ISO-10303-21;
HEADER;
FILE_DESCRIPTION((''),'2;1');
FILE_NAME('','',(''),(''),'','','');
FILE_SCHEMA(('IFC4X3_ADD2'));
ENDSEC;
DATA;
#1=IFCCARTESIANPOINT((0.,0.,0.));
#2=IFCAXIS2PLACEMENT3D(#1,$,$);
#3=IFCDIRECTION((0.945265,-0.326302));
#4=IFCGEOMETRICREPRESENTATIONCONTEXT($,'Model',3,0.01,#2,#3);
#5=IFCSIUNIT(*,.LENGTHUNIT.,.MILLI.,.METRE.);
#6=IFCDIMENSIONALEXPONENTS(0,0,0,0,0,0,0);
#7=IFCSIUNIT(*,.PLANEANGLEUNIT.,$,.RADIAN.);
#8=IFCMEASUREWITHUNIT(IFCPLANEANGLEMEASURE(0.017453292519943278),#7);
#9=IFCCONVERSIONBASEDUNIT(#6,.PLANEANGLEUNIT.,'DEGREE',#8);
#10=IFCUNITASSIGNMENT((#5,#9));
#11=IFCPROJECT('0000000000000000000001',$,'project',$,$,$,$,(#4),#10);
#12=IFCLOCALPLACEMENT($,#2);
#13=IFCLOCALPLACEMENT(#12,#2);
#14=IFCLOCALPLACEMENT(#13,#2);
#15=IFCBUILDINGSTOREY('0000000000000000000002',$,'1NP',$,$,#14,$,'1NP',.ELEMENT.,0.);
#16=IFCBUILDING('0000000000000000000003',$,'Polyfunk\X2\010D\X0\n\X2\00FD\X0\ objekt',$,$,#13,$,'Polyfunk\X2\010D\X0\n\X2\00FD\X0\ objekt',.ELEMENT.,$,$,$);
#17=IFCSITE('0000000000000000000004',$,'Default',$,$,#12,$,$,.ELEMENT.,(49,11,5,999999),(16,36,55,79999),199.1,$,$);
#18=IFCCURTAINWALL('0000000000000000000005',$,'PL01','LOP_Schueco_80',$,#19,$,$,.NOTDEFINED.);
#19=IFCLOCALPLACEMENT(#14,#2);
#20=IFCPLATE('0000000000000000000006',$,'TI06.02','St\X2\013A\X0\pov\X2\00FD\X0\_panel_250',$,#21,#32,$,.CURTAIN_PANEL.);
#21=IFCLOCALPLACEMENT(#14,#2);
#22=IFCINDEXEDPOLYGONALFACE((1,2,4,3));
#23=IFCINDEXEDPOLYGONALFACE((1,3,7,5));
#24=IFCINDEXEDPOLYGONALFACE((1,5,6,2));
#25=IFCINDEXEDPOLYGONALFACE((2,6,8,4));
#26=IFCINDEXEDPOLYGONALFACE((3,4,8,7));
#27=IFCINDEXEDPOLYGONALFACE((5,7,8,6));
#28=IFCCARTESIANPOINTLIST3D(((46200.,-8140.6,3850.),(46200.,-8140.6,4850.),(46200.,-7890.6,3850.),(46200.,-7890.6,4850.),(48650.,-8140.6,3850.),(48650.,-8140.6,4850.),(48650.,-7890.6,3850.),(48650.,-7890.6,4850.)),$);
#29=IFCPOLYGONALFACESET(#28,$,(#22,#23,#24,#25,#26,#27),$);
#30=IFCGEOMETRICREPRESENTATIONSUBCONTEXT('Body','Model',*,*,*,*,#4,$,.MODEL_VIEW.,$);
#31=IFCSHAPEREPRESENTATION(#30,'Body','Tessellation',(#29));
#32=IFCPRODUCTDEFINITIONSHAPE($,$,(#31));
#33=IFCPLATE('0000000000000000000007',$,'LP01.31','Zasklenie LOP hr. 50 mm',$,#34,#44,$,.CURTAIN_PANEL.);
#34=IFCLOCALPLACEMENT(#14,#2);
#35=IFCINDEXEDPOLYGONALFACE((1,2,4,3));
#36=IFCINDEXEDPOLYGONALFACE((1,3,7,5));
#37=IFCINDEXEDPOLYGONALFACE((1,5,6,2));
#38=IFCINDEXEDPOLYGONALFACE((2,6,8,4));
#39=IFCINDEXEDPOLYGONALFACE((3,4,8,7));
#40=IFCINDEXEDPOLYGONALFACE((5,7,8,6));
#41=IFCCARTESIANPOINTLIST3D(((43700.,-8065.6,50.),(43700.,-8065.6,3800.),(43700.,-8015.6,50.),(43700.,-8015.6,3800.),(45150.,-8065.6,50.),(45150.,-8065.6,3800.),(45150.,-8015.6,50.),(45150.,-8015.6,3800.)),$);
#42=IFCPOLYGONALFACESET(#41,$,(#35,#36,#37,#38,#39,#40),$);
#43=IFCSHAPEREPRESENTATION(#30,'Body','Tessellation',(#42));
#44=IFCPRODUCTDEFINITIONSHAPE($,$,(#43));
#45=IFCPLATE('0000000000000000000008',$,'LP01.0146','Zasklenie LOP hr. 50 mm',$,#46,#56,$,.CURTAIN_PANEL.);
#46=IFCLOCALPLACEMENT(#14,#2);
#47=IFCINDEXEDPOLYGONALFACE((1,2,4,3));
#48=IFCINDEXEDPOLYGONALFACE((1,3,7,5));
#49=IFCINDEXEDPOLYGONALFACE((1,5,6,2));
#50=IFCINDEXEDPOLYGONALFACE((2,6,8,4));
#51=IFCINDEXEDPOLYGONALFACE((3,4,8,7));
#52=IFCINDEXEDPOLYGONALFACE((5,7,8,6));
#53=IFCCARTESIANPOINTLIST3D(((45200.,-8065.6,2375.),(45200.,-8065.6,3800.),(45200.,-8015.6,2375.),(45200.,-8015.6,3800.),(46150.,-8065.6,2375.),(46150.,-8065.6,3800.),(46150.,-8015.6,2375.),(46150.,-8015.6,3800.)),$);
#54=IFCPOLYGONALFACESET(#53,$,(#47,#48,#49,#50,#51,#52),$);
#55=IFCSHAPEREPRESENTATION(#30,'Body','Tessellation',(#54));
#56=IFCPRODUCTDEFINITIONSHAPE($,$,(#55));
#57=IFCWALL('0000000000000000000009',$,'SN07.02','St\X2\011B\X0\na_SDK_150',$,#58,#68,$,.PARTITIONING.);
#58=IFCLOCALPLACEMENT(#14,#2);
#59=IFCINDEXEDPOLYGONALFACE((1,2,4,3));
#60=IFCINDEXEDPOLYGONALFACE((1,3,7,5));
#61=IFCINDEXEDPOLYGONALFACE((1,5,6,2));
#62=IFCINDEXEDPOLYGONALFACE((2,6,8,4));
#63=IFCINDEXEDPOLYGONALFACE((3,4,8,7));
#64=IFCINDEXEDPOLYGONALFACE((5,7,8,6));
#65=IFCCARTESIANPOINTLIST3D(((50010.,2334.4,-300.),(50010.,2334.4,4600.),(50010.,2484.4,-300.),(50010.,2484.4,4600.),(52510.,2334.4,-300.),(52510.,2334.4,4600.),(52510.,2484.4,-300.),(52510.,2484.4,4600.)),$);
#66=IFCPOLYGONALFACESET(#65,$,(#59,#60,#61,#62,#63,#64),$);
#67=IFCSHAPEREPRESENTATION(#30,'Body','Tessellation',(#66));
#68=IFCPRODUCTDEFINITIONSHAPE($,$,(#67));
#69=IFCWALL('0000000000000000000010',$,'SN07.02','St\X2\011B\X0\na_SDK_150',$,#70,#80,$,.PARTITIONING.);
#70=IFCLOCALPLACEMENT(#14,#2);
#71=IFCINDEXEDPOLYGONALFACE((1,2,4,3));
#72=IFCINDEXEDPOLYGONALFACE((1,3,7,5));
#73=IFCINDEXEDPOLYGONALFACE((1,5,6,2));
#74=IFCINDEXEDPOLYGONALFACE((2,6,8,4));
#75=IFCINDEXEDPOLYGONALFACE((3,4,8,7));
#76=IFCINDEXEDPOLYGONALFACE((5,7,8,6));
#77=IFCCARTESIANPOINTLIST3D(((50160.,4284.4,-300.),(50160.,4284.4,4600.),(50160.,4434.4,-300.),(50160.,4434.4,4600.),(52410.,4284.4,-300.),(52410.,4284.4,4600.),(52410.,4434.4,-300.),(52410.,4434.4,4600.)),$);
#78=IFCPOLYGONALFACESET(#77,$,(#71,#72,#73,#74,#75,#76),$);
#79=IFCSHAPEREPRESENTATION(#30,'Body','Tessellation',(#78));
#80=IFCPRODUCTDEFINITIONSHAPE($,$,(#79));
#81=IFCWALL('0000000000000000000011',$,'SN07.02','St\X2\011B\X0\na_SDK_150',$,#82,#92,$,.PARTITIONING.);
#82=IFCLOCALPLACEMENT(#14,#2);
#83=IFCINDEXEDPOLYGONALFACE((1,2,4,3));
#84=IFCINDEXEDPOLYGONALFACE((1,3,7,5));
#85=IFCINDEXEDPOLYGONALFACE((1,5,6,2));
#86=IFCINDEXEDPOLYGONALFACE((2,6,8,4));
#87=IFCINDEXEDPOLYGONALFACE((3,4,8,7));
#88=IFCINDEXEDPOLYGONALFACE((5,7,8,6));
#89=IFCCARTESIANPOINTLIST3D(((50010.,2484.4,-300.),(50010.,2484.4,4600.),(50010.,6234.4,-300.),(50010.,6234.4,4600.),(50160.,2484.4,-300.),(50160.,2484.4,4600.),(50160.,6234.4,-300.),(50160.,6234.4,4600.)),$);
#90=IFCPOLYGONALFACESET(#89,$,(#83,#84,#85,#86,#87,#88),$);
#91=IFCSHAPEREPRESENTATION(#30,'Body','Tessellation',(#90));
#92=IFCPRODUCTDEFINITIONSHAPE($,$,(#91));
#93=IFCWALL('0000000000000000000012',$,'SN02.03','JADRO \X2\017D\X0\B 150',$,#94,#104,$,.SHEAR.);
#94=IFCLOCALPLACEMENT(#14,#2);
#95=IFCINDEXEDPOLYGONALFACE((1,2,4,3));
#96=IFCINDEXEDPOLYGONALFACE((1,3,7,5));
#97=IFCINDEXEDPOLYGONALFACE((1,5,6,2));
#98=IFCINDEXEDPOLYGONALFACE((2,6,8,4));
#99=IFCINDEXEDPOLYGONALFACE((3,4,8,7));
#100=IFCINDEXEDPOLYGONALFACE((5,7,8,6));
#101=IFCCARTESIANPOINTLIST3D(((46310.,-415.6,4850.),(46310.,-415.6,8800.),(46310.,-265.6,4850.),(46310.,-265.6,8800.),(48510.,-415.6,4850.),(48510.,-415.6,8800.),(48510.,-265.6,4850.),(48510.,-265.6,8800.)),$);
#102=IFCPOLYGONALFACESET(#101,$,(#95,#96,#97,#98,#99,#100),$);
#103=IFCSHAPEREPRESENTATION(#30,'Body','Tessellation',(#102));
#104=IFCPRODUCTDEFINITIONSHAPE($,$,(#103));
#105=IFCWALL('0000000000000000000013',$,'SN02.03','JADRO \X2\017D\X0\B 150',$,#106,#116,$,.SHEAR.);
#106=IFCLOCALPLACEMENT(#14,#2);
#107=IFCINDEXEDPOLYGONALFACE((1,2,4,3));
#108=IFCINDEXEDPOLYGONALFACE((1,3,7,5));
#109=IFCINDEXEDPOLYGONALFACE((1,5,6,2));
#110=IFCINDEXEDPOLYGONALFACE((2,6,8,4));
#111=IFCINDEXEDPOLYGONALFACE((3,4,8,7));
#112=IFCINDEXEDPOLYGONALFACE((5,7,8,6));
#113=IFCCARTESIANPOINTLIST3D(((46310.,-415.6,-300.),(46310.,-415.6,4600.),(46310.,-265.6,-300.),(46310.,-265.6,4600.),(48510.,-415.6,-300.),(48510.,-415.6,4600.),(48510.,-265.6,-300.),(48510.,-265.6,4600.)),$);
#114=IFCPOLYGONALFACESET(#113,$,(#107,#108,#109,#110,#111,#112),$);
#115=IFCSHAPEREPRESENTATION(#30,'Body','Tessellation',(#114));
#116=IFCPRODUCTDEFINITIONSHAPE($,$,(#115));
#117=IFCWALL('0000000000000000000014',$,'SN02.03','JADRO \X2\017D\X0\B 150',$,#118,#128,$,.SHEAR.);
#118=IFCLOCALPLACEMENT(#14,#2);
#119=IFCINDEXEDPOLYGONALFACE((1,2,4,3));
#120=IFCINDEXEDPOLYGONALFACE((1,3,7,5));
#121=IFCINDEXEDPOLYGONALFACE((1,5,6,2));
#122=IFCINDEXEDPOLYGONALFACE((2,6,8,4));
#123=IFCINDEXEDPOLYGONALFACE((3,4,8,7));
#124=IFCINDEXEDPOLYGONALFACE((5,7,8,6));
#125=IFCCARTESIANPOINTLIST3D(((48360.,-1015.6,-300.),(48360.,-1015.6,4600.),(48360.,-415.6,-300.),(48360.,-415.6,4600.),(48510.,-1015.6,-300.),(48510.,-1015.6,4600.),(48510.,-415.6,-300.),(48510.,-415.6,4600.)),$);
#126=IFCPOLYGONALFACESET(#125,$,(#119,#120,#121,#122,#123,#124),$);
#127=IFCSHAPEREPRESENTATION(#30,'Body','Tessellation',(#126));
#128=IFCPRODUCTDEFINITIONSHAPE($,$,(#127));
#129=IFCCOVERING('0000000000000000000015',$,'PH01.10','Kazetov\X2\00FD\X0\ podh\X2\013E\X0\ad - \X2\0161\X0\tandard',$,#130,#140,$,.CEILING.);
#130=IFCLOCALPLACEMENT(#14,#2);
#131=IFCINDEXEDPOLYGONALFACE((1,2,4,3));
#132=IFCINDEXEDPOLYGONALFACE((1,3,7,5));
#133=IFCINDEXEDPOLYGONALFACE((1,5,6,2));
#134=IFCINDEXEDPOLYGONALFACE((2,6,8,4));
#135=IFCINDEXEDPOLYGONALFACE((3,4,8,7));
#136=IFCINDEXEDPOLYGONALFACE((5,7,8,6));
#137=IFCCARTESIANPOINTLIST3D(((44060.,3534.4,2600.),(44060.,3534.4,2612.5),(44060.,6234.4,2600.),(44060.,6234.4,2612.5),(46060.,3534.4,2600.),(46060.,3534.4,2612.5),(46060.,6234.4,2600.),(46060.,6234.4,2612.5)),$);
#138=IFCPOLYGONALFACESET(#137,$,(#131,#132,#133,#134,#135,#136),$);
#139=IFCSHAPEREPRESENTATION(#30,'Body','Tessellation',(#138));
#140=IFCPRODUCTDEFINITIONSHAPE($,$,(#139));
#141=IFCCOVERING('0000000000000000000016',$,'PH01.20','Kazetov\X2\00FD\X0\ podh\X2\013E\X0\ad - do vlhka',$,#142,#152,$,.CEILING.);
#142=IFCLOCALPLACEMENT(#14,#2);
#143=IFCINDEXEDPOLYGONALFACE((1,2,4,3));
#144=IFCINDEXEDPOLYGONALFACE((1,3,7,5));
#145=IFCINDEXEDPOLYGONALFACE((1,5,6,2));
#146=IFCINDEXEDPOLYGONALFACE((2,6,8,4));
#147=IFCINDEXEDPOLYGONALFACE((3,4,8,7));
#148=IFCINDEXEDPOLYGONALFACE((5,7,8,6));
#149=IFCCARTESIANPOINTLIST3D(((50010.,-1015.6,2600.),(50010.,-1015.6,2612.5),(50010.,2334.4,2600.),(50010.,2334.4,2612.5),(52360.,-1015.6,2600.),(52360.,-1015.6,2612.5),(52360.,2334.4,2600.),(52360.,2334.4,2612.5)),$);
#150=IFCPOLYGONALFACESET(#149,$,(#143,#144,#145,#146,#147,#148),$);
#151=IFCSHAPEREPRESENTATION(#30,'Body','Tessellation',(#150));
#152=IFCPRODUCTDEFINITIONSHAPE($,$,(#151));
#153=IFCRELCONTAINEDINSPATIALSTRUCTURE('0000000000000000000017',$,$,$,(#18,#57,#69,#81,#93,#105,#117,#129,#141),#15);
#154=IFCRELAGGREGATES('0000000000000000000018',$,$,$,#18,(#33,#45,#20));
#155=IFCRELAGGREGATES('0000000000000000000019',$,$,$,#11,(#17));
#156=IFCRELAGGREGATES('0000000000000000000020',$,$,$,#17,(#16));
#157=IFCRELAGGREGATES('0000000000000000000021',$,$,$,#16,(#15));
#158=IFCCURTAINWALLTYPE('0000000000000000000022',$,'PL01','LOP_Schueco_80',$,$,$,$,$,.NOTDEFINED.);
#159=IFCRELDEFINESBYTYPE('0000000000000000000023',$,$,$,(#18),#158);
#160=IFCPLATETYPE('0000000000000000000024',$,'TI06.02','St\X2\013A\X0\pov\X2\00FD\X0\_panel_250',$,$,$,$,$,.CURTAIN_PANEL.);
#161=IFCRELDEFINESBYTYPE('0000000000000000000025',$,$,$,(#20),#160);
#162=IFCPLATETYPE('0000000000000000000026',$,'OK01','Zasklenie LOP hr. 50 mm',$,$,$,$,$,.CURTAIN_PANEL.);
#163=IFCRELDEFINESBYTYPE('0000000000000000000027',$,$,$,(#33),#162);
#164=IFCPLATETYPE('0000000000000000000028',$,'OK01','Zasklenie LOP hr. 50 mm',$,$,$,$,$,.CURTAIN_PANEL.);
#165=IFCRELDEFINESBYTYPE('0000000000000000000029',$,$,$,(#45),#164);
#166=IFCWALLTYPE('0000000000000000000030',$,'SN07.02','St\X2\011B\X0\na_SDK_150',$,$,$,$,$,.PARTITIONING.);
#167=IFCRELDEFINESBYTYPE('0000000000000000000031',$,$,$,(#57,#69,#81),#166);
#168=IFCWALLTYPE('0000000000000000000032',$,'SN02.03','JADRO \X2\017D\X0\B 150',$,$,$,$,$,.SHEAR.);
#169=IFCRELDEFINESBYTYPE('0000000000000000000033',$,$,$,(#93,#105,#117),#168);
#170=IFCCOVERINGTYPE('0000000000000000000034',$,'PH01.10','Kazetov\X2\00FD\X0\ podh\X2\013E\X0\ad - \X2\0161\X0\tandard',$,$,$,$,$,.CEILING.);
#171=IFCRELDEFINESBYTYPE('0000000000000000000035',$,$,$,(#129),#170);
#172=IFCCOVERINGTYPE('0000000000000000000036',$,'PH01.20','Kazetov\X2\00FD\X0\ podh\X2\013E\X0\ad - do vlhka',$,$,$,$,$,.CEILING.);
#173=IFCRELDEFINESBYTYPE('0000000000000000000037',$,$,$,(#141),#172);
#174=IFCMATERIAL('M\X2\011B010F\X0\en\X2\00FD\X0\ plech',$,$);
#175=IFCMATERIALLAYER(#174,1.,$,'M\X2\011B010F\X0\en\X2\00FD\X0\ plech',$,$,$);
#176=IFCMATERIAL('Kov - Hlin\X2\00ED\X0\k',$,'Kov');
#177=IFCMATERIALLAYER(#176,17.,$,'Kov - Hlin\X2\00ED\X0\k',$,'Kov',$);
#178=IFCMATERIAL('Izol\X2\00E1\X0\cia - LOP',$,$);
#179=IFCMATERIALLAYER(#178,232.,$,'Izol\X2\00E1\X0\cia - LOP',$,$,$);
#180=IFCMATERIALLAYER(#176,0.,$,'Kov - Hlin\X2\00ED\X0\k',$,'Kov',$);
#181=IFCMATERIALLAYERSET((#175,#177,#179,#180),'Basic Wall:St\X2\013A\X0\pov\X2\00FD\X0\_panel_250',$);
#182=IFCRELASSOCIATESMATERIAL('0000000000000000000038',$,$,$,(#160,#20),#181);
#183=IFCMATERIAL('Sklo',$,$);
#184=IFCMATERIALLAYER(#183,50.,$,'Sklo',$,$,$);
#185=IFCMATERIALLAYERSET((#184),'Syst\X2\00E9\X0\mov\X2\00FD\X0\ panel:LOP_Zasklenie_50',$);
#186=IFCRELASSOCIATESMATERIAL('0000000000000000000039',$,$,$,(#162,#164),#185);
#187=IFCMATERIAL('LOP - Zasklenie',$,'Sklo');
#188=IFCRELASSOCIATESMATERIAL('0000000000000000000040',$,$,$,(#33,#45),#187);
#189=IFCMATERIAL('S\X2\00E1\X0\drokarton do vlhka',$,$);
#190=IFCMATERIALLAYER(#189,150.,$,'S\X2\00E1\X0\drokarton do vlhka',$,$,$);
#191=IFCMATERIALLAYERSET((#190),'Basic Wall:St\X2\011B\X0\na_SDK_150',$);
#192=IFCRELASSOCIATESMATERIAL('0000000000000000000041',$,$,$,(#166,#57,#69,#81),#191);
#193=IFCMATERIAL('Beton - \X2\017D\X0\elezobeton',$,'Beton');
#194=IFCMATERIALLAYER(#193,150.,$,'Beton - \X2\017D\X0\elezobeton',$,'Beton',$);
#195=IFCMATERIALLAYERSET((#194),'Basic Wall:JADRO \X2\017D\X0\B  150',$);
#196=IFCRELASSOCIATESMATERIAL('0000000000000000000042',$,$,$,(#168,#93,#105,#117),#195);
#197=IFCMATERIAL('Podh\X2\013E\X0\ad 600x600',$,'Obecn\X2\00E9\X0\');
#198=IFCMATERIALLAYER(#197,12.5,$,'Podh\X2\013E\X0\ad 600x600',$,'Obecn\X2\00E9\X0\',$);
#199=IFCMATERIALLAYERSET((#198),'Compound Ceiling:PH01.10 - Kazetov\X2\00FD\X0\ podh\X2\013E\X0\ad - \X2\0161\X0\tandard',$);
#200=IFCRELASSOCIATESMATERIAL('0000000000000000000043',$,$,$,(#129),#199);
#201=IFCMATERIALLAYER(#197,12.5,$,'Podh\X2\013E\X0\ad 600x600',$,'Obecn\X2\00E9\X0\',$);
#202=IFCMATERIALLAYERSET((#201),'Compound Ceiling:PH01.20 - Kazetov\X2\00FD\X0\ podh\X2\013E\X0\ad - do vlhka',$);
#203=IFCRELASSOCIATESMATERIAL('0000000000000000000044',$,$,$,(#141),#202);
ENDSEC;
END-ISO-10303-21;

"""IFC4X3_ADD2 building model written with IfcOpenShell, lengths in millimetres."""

from ifc_helpers import new_model, entity, si_unit, converted_unit, direction, frame, frame_2d, origin, origin_2d_with_axis, place, context, subcontext, project, spatial, polyline, rectangle, extrude, clip, bounded_halfspace, source, transform, mapped, material, layer, layer_set, layer_usage, type_object, type_shapes, element, aggregate, save


model = new_model("IFC4X3_ADD2")

# Units and contexts
model_context = context("Model", 3, precision=0.01, world=origin(), true_north=direction((0.945265, -0.326302)))
body_context = subcontext(model_context, "Body", "Model", "MODEL_VIEW")
ifc_project = project(units=[si_unit("LENGTHUNIT", "METRE", prefix="MILLI"), converted_unit("PLANEANGLEUNIT", "DEGREE", entity("IfcPlaneAngleMeasure", 0.017453292519943278), si_unit("PLANEANGLEUNIT", "RADIAN"), dimensions=[0, 0, 0, 0, 0, 0, 0])], contexts=[model_context])

# Site, building, storey
site_placement = place(None, origin())
site = spatial("IfcSite", under=ifc_project, at=site_placement, Name="Default", CompositionType="ELEMENT", RefLatitude=(49, 11, 5, 999999), RefLongitude=(16, 36, 55, 79999), RefElevation=199.1)
building_placement = place(site_placement, origin())
building = spatial("IfcBuilding", under=site, at=building_placement, Name="Polyfunkčný objekt", LongName="Polyfunkčný objekt", CompositionType="ELEMENT")
storey_placement = place(building_placement, origin())
storey = spatial("IfcBuildingStorey", under=building, at=storey_placement, Name="1NP", LongName="1NP", CompositionType="ELEMENT", Elevation=0.0)

# Curtain wall, plates
curtain_wall_type = type_object("IfcCurtainWallType", Name="PL01", Description="LOP_Schueco_80", PredefinedType="NOTDEFINED")
curtain_wall_placement = place(storey_placement, origin())
curtain_wall = element("IfcCurtainWall", 1, at=curtain_wall_placement, inside=storey, type_object=curtain_wall_type, Name="PL01", Description="LOP_Schueco_80", PredefinedType="NOTDEFINED")
ifc_material_1 = material(Name="Měďený plech")
ifc_layer_1 = layer(ifc_material_1, 1.0, Name="Měďený plech")
ifc_material_2 = material(Name="Kov - Hliník", Category="Kov")
ifc_layer_2 = layer(ifc_material_2, 17.0, Name="Kov - Hliník", Category="Kov")
ifc_material_3 = material(Name="Izolácia - LOP")
ifc_layer_3 = layer(ifc_material_3, 232.0, Name="Izolácia - LOP")
ifc_layer_4 = layer(ifc_material_2, 0.0, Name="Kov - Hliník", Category="Kov")
ifc_layer_set_1 = layer_set([ifc_layer_1, ifc_layer_2, ifc_layer_3, ifc_layer_4], Name="Basic Wall:Stĺpový_panel_250")
ifc_layer_usage_1 = layer_usage(ifc_layer_set_1, "AXIS2", "POSITIVE", -125.0)
plate_type_1 = type_object("IfcPlateType", Name="TI06.02", Description="Stĺpový_panel_250", PredefinedType="CURTAIN_PANEL", material=ifc_layer_set_1)
plate_1_placement = place(storey_placement, frame((46200.0, -8015.6, 3850.0)))
plate_1 = element("IfcPlate", 2, at=plate_1_placement, type_object=plate_type_1, material=ifc_layer_usage_1, Name="TI06.02", Description="Stĺpový_panel_250", PredefinedType="CURTAIN_PANEL", context=body_context, shape_type="SweptSolid", body=[
    extrude(rectangle(XDim=250.0, YDim=2450.0, at=origin_2d_with_axis()), frame((1225.0, 0.0, 0.0), z_axis=(0.0, 0.0, 1.0), x_axis=(0.0, 1.0, 0.0)), (0.0, 0.0, 1.0), 1000.0),
])
ifc_material_4 = material(Name="LOP - Zasklenie", Category="Sklo")
ifc_material_5 = material(Name="Sklo")
ifc_layer_5 = layer(ifc_material_5, 50.0, Name="Sklo")
ifc_layer_set_2 = layer_set([ifc_layer_5], Name="Systémový panel:LOP_Zasklenie_50")
plate_type_2 = type_object("IfcPlateType", Name="OK01", Description="Zasklenie LOP hr. 50 mm", PredefinedType="CURTAIN_PANEL", material=ifc_layer_set_2)
shared_shape_1 = source(origin(), body_context, "Body", "SweptSolid", [
    extrude(rectangle(XDim=3750.0, YDim=1450.0, at=frame_2d((-331.2, 0.0), x_axis=(1.0, 0.0))), frame((0.0, -50.0, 2206.2), z_axis=(0.0, 1.0, 0.0), x_axis=(0.0, 0.0, 1.0)), (0.0, 0.0, 1.0), 50.0),
])
type_shapes(plate_type_2, [shared_shape_1])
plate_2_placement = place(curtain_wall_placement, frame((44425.0, -8015.6, 50.0)))
plate_2 = element("IfcPlate", 3, at=plate_2_placement, type_object=plate_type_2, material=ifc_material_4, Name="LP01.31", Description="Zasklenie LOP hr. 50 mm", PredefinedType="CURTAIN_PANEL", context=body_context, shape_type="MappedRepresentation", body=[
    mapped(shared_shape_1, transform((0.0, 0.0, 0.0), scale=1.0)),
])
plate_type_3 = type_object("IfcPlateType", Name="OK01", Description="Zasklenie LOP hr. 50 mm", PredefinedType="CURTAIN_PANEL", material=ifc_layer_set_2)
shared_shape_2 = source(origin(), body_context, "Body", "SweptSolid", [
    extrude(rectangle(XDim=1425.0, YDim=950.0, at=frame_2d((87.6, 0.0), x_axis=(1.0, 0.0))), frame((0.0, -50.0, 624.9), z_axis=(0.0, 1.0, 0.0), x_axis=(0.0, 0.0, 1.0)), (0.0, 0.0, 1.0), 50.0),
])
type_shapes(plate_type_3, [shared_shape_2])
plate_3_placement = place(curtain_wall_placement, frame((45675.0, -8015.6, 2375.0)))
plate_3 = element("IfcPlate", 4, at=plate_3_placement, type_object=plate_type_3, material=ifc_material_4, Name="LP01.0146", Description="Zasklenie LOP hr. 50 mm", PredefinedType="CURTAIN_PANEL", context=body_context, shape_type="MappedRepresentation", body=[
    mapped(shared_shape_2, transform((0.0, 0.0, 0.0), scale=1.0)),
])
aggregate(curtain_wall, [plate_2, plate_3, plate_1])

# Walls
ifc_material_6 = material(Name="Sádrokarton do vlhka")
ifc_layer_6 = layer(ifc_material_6, 150.0, Name="Sádrokarton do vlhka")
ifc_layer_set_3 = layer_set([ifc_layer_6], Name="Basic Wall:Stěna_SDK_150")
wall_type_1 = type_object("IfcWallType", Name="SN07.02", Description="Stěna_SDK_150", PredefinedType="PARTITIONING", material=ifc_layer_set_3)
wall_1_placement = place(storey_placement, frame((50010.0, 2409.4, -300.0)))
element("IfcWall", 5, at=wall_1_placement, inside=storey, type_object=wall_type_1, material=ifc_layer_set_3, Name="SN07.02", Description="Stěna_SDK_150", PredefinedType="PARTITIONING", context=body_context, shape_type="Clipping", body=[
    clip(clip(extrude(rectangle(XDim=2500.0, YDim=150.0, at=frame_2d((1250.0, 0.0), x_axis=(-1.0, 0.0))), origin(), (0.0, 0.0, 1.0), 4900.0), bounded_halfspace(frame((2500.0, -75.0, 0.0), z_axis=(0.0, 0.0, 1.0), x_axis=(0.0, 1.0, 0.0)), True, frame((2500.0, -75.0, 0.0)), polyline([(0.0, 0.0), (0.0, 150.0), (-100.0, 150.0), (-2350.0, 150.0), (-2500.0, 150.0), (-2500.0, 0.0), (-150.0, 0.0), (0.0, 0.0)]))), bounded_halfspace(frame((0.0, -75.0, 4900.0), z_axis=(0.0, 0.0, -1.0), x_axis=(1.0, 0.0, 0.0)), True, frame((0.0, -75.0, 4900.0)), polyline([(0.0, 0.0), (2350.0, 0.0), (2500.0, 0.0), (2500.0, 150.0), (2400.0, 150.0), (150.0, 150.0), (0.0, 150.0), (0.0, 0.0)]))),
])
wall_2_placement = place(storey_placement, frame((50160.0, 4359.4, -300.0)))
element("IfcWall", 6, at=wall_2_placement, inside=storey, type_object=wall_type_1, material=ifc_layer_set_3, Name="SN07.02", Description="Stěna_SDK_150", PredefinedType="PARTITIONING", context=body_context, shape_type="Clipping", body=[
    clip(clip(extrude(rectangle(XDim=2250.0, YDim=150.0, at=frame_2d((1125.0, 0.0), x_axis=(-1.0, 0.0))), origin(), (0.0, 0.0, 1.0), 4900.0), bounded_halfspace(frame((2250.0, -75.0, 0.0), z_axis=(0.0, 0.0, 1.0), x_axis=(0.0, 1.0, 0.0)), True, frame((2250.0, -75.0, 0.0)), polyline([(0.0, 0.0), (0.0, 150.0), (-2250.0, 150.0), (-2250.0, 0.0), (0.0, 0.0)]))), bounded_halfspace(frame((0.0, -75.0, 4900.0), z_axis=(0.0, 0.0, -1.0), x_axis=(1.0, 0.0, 0.0)), True, frame((0.0, -75.0, 4900.0)), polyline([(0.0, 0.0), (2250.0, 0.0), (2250.0, 150.0), (0.0, 150.0), (0.0, 0.0)]))),
])
wall_3_placement = place(storey_placement, frame((50085.0, 2484.4, -300.0), z_axis=(0.0, 0.0, 1.0), x_axis=(0.0, 1.0, 0.0)))
element("IfcWall", 7, at=wall_3_placement, inside=storey, type_object=wall_type_1, material=ifc_layer_set_3, Name="SN07.02", Description="Stěna_SDK_150", PredefinedType="PARTITIONING", context=body_context, shape_type="Clipping", body=[
    clip(clip(extrude(rectangle(XDim=3750.0, YDim=150.0, at=frame_2d((1875.0, 0.0), x_axis=(-1.0, 0.0))), origin(), (0.0, 0.0, 1.0), 4900.0), bounded_halfspace(frame((0.0, -75.0, 4900.0), z_axis=(0.0, 0.0, -1.0), x_axis=(0.0, -1.0, 0.0)), True, frame((0.0, -75.0, 4900.0)), polyline([(0.0, 0.0), (1800.0, 0.0), (1950.0, 0.0), (3750.0, 0.0), (3750.0, 150.0), (0.0, 150.0), (0.0, 0.0)]))), bounded_halfspace(frame((3750.0, -75.0, 0.0)), True, frame((3750.0, -75.0, 0.0)), polyline([(0.0, 0.0), (0.0, 150.0), (-3750.0, 150.0), (-3750.0, 0.0), (-1950.0, 0.0), (-1800.0, 0.0), (0.0, 0.0)]))),
])
ifc_material_7 = material(Name="Beton - Železobeton", Category="Beton")
ifc_layer_7 = layer(ifc_material_7, 150.0, Name="Beton - Železobeton", Category="Beton")
ifc_layer_set_4 = layer_set([ifc_layer_7], Name="Basic Wall:JADRO ŽB  150")
wall_type_2 = type_object("IfcWallType", Name="SN02.03", Description="JADRO ŽB 150", PredefinedType="SHEAR", material=ifc_layer_set_4)
wall_4_placement = place(storey_placement, frame((46310.0, -340.6, 4850.0)))
element("IfcWall", 8, at=wall_4_placement, inside=storey, type_object=wall_type_2, material=ifc_layer_set_4, Name="SN02.03", Description="JADRO ŽB 150", PredefinedType="SHEAR", context=body_context, shape_type="Clipping", body=[
    clip(clip(extrude(rectangle(XDim=2200.0, YDim=150.0, at=frame_2d((1100.0, 0.0), x_axis=(-1.0, 0.0))), origin(), (0.0, 0.0, 1.0), 3950.0), bounded_halfspace(frame((2200.0, -75.0, 0.0), z_axis=(0.0, 0.0, 1.0), x_axis=(-1.0, 0.0, 0.0)), True, frame((2200.0, -75.0, 0.0)), polyline([(0.0, 0.0), (0.0, 150.0), (-2200.0, 150.0), (-2200.0, 0.0), (0.0, 0.0)]))), bounded_halfspace(frame((0.0, -75.0, 3950.0), z_axis=(0.0, 0.0, -1.0), x_axis=(1.0, 0.0, 0.0)), True, frame((0.0, -75.0, 3950.0)), polyline([(0.0, 0.0), (2050.0, 0.0), (2200.0, 0.0), (2200.0, 150.0), (0.0, 150.0), (0.0, 0.0)]))),
])
wall_5_placement = place(storey_placement, frame((46310.0, -340.6, -300.0)))
element("IfcWall", 9, at=wall_5_placement, inside=storey, type_object=wall_type_2, material=ifc_layer_set_4, Name="SN02.03", Description="JADRO ŽB 150", PredefinedType="SHEAR", context=body_context, shape_type="SweptSolid", body=[
    extrude(rectangle(XDim=2200.0, YDim=150.0, at=frame_2d((1100.0, 0.0), x_axis=(-1.0, 0.0))), origin(), (0.0, 0.0, 1.0), 4900.0),
])
wall_6_placement = place(storey_placement, frame((48435.0, -1015.6, -300.0), z_axis=(0.0, 0.0, 1.0), x_axis=(0.0, 1.0, 0.0)))
element("IfcWall", 10, at=wall_6_placement, inside=storey, type_object=wall_type_2, material=ifc_layer_set_4, Name="SN02.03", Description="JADRO ŽB 150", PredefinedType="SHEAR", context=body_context, shape_type="SweptSolid", body=[
    extrude(rectangle(XDim=600.0, YDim=150.0, at=frame_2d((300.0, 0.0), x_axis=(-1.0, 0.0))), origin(), (0.0, 0.0, 1.0), 4900.0),
])

# Coverings
ifc_material_8 = material(Name="Podhľad 600x600", Category="Obecné")
ifc_layer_8 = layer(ifc_material_8, 12.5, Name="Podhľad 600x600", Category="Obecné")
ifc_layer_set_5 = layer_set([ifc_layer_8], Name="Compound Ceiling:PH01.10 - Kazetový podhľad - štandard")
ifc_layer_usage_2 = layer_usage(ifc_layer_set_5, "AXIS3", "NEGATIVE", 0.0)
covering_type_1 = type_object("IfcCoveringType", Name="PH01.10", Description="Kazetový podhľad - štandard", PredefinedType="CEILING")
covering_1_placement = place(storey_placement, frame((44060.0, 3534.4, 2600.0)))
element("IfcCovering", 11, at=covering_1_placement, inside=storey, type_object=covering_type_1, material=ifc_layer_usage_2, Name="PH01.10", Description="Kazetový podhľad - štandard", PredefinedType="CEILING", context=body_context, shape_type="SweptSolid", body=[
    extrude(rectangle(XDim=2000.0, YDim=2700.0, at=frame_2d((0.0, 0.0), x_axis=(1.0, 0.0))), frame((1000.0, 1350.0, 0.0)), (0.0, 0.0, 1.0), 12.5),
])
ifc_layer_9 = layer(ifc_material_8, 12.5, Name="Podhľad 600x600", Category="Obecné")
ifc_layer_set_6 = layer_set([ifc_layer_9], Name="Compound Ceiling:PH01.20 - Kazetový podhľad - do vlhka")
ifc_layer_usage_3 = layer_usage(ifc_layer_set_6, "AXIS3", "NEGATIVE", 12.5)
covering_type_2 = type_object("IfcCoveringType", Name="PH01.20", Description="Kazetový podhľad - do vlhka", PredefinedType="CEILING")
covering_2_placement = place(storey_placement, frame((50010.0, -1015.6, 2600.0)))
element("IfcCovering", 12, at=covering_2_placement, inside=storey, type_object=covering_type_2, material=ifc_layer_usage_3, Name="PH01.20", Description="Kazetový podhľad - do vlhka", PredefinedType="CEILING", context=body_context, shape_type="SweptSolid", body=[
    extrude(rectangle(XDim=3350.0, YDim=2350.0, at=frame_2d((0.0, 0.0), x_axis=(1.0, 0.0))), frame((1175.0, 1675.0, 0.0), z_axis=(0.0, 0.0, 1.0), x_axis=(0.0, 1.0, 0.0)), (0.0, 0.0, 1.0), 12.5),
])

save(model, "model.ifc")
